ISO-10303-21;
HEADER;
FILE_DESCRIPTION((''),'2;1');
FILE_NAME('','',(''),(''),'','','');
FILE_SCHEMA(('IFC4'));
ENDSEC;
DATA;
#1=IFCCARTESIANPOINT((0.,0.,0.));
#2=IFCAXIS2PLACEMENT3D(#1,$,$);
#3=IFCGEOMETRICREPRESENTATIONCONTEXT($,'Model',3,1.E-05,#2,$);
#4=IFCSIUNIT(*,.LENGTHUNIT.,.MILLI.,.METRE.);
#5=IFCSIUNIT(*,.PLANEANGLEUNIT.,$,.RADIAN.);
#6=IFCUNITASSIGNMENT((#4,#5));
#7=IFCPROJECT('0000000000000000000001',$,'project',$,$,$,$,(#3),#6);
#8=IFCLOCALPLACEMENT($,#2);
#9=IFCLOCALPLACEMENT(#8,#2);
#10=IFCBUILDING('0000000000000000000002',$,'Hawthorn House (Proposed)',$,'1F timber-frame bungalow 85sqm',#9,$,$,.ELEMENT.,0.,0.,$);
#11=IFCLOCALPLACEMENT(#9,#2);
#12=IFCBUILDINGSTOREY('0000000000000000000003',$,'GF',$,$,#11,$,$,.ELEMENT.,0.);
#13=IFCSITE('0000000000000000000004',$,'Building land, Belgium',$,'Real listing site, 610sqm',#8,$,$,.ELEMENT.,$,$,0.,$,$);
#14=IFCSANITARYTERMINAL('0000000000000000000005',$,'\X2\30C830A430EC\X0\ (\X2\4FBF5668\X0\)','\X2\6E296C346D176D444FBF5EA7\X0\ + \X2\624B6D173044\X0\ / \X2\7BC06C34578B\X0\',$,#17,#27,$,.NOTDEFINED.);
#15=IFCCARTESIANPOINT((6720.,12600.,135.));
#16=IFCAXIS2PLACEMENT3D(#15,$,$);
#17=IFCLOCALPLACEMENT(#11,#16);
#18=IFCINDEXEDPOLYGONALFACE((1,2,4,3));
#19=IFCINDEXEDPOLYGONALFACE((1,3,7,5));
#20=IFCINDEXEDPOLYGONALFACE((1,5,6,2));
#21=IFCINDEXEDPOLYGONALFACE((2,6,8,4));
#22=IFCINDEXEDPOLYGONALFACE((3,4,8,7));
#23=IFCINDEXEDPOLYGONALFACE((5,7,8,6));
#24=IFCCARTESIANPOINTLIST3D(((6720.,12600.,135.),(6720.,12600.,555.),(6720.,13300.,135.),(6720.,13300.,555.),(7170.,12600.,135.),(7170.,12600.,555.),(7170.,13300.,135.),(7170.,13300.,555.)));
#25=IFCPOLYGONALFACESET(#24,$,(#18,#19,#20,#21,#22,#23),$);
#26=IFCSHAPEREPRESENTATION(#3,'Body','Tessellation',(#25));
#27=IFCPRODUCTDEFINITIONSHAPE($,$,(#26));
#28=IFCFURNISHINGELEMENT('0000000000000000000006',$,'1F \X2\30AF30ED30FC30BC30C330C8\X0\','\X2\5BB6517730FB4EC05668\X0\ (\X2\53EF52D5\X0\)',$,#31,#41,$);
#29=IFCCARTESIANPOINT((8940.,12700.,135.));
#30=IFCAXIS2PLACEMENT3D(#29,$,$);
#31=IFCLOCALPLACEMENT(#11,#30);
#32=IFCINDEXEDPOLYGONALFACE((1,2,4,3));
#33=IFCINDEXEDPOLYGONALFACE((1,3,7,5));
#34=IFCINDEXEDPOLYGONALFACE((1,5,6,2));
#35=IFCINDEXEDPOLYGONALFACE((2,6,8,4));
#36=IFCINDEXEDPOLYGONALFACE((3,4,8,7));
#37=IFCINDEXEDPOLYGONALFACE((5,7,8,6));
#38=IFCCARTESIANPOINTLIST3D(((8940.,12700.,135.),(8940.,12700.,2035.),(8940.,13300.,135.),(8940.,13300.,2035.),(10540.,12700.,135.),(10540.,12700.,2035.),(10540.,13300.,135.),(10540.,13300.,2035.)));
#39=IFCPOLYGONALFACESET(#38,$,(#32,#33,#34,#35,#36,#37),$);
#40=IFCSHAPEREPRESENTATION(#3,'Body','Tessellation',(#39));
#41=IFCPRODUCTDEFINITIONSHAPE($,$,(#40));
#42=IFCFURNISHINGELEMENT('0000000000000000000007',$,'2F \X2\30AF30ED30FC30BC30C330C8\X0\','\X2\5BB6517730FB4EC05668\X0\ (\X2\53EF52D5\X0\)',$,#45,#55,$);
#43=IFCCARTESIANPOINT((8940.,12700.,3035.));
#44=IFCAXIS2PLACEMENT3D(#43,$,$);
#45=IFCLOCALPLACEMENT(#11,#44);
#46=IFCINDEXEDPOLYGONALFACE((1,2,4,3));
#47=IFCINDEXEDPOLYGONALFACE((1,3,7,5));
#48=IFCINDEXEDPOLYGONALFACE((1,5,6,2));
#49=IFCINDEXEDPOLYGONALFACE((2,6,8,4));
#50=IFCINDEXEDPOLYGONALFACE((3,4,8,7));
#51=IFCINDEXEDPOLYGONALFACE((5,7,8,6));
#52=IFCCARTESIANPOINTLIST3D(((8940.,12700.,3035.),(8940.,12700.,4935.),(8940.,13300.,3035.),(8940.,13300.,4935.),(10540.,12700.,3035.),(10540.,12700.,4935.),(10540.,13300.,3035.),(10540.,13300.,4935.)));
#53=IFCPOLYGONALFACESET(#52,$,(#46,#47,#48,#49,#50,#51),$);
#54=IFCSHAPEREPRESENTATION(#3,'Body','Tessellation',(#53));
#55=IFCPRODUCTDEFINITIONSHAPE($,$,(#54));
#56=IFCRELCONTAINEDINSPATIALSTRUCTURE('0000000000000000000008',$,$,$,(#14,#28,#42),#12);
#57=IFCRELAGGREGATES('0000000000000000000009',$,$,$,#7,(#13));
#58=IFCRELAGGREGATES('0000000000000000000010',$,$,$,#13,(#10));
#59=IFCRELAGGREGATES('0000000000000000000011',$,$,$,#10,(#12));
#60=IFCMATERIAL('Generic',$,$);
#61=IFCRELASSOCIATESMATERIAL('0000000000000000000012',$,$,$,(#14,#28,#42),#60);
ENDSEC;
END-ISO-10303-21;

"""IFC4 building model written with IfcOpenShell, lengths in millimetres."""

from ifc_helpers import new_model, si_unit, frame, frame_2d, origin, place, context, project, spatial, rectangle, extrude, material, element, save


model = new_model("IFC4")

# Units and contexts
model_context = context("Model", 3, precision=1e-05, world=origin())
ifc_project = project(units=[si_unit("LENGTHUNIT", "METRE", prefix="MILLI"), si_unit("PLANEANGLEUNIT", "RADIAN")], contexts=[model_context])

# Site, building, storey
site_placement = place(None, origin())
site = spatial("IfcSite", under=ifc_project, at=site_placement, Name="Building land, Belgium", ObjectType="Real listing site, 610sqm", CompositionType="ELEMENT", RefElevation=0.0)
building_placement = place(site_placement, origin())
building = spatial("IfcBuilding", under=site, at=building_placement, Name="Hawthorn House (Proposed)", ObjectType="1F timber-frame bungalow 85sqm", CompositionType="ELEMENT", ElevationOfRefHeight=0.0, ElevationOfTerrain=0.0)
storey_placement = place(building_placement, origin())
storey = spatial("IfcBuildingStorey", under=building, at=storey_placement, Name="GF", CompositionType="ELEMENT", Elevation=0.0)

# Sanitary terminal
ifc_material_1 = material(Name="Generic")
sanitary_terminal_1_placement = place(storey_placement, frame((6720.0, 12600.0, 135.0)))
element("IfcSanitaryTerminal", 1, at=sanitary_terminal_1_placement, inside=storey, material=ifc_material_1, Name="トイレ (便器)", Description="温水洗浄便座 + 手洗い / 節水型", PredefinedType="NOTDEFINED", context=model_context, shape_type="SweptSolid", body=[
    extrude(rectangle(XDim=450.0, YDim=700.0, at=frame_2d((225.0, 350.0))), frame((6720.0, 12600.0, 135.0)), (0.0, 0.0, 1.0), 420.0),
])

# Furnishing elements
furnishing_1_placement = place(storey_placement, frame((8940.0, 12700.0, 135.0)))
element("IfcFurnishingElement", 2, at=furnishing_1_placement, inside=storey, material=ifc_material_1, Name="1F クローゼット", Description="家具・什器 (可動)", context=model_context, shape_type="SweptSolid", body=[
    extrude(rectangle(XDim=1600.0, YDim=600.0, at=frame_2d((800.0, 300.0))), frame((8940.0, 12700.0, 135.0)), (0.0, 0.0, 1.0), 1900.0),
])
furnishing_2_placement = place(storey_placement, frame((8940.0, 12700.0, 3035.0)))
element("IfcFurnishingElement", 3, at=furnishing_2_placement, inside=storey, material=ifc_material_1, Name="2F クローゼット", Description="家具・什器 (可動)", context=model_context, shape_type="SweptSolid", body=[
    extrude(rectangle(XDim=1600.0, YDim=600.0, at=frame_2d((800.0, 300.0))), frame((8940.0, 12700.0, 3035.0)), (0.0, 0.0, 1.0), 1900.0),
])

save(model, "model.ifc")
